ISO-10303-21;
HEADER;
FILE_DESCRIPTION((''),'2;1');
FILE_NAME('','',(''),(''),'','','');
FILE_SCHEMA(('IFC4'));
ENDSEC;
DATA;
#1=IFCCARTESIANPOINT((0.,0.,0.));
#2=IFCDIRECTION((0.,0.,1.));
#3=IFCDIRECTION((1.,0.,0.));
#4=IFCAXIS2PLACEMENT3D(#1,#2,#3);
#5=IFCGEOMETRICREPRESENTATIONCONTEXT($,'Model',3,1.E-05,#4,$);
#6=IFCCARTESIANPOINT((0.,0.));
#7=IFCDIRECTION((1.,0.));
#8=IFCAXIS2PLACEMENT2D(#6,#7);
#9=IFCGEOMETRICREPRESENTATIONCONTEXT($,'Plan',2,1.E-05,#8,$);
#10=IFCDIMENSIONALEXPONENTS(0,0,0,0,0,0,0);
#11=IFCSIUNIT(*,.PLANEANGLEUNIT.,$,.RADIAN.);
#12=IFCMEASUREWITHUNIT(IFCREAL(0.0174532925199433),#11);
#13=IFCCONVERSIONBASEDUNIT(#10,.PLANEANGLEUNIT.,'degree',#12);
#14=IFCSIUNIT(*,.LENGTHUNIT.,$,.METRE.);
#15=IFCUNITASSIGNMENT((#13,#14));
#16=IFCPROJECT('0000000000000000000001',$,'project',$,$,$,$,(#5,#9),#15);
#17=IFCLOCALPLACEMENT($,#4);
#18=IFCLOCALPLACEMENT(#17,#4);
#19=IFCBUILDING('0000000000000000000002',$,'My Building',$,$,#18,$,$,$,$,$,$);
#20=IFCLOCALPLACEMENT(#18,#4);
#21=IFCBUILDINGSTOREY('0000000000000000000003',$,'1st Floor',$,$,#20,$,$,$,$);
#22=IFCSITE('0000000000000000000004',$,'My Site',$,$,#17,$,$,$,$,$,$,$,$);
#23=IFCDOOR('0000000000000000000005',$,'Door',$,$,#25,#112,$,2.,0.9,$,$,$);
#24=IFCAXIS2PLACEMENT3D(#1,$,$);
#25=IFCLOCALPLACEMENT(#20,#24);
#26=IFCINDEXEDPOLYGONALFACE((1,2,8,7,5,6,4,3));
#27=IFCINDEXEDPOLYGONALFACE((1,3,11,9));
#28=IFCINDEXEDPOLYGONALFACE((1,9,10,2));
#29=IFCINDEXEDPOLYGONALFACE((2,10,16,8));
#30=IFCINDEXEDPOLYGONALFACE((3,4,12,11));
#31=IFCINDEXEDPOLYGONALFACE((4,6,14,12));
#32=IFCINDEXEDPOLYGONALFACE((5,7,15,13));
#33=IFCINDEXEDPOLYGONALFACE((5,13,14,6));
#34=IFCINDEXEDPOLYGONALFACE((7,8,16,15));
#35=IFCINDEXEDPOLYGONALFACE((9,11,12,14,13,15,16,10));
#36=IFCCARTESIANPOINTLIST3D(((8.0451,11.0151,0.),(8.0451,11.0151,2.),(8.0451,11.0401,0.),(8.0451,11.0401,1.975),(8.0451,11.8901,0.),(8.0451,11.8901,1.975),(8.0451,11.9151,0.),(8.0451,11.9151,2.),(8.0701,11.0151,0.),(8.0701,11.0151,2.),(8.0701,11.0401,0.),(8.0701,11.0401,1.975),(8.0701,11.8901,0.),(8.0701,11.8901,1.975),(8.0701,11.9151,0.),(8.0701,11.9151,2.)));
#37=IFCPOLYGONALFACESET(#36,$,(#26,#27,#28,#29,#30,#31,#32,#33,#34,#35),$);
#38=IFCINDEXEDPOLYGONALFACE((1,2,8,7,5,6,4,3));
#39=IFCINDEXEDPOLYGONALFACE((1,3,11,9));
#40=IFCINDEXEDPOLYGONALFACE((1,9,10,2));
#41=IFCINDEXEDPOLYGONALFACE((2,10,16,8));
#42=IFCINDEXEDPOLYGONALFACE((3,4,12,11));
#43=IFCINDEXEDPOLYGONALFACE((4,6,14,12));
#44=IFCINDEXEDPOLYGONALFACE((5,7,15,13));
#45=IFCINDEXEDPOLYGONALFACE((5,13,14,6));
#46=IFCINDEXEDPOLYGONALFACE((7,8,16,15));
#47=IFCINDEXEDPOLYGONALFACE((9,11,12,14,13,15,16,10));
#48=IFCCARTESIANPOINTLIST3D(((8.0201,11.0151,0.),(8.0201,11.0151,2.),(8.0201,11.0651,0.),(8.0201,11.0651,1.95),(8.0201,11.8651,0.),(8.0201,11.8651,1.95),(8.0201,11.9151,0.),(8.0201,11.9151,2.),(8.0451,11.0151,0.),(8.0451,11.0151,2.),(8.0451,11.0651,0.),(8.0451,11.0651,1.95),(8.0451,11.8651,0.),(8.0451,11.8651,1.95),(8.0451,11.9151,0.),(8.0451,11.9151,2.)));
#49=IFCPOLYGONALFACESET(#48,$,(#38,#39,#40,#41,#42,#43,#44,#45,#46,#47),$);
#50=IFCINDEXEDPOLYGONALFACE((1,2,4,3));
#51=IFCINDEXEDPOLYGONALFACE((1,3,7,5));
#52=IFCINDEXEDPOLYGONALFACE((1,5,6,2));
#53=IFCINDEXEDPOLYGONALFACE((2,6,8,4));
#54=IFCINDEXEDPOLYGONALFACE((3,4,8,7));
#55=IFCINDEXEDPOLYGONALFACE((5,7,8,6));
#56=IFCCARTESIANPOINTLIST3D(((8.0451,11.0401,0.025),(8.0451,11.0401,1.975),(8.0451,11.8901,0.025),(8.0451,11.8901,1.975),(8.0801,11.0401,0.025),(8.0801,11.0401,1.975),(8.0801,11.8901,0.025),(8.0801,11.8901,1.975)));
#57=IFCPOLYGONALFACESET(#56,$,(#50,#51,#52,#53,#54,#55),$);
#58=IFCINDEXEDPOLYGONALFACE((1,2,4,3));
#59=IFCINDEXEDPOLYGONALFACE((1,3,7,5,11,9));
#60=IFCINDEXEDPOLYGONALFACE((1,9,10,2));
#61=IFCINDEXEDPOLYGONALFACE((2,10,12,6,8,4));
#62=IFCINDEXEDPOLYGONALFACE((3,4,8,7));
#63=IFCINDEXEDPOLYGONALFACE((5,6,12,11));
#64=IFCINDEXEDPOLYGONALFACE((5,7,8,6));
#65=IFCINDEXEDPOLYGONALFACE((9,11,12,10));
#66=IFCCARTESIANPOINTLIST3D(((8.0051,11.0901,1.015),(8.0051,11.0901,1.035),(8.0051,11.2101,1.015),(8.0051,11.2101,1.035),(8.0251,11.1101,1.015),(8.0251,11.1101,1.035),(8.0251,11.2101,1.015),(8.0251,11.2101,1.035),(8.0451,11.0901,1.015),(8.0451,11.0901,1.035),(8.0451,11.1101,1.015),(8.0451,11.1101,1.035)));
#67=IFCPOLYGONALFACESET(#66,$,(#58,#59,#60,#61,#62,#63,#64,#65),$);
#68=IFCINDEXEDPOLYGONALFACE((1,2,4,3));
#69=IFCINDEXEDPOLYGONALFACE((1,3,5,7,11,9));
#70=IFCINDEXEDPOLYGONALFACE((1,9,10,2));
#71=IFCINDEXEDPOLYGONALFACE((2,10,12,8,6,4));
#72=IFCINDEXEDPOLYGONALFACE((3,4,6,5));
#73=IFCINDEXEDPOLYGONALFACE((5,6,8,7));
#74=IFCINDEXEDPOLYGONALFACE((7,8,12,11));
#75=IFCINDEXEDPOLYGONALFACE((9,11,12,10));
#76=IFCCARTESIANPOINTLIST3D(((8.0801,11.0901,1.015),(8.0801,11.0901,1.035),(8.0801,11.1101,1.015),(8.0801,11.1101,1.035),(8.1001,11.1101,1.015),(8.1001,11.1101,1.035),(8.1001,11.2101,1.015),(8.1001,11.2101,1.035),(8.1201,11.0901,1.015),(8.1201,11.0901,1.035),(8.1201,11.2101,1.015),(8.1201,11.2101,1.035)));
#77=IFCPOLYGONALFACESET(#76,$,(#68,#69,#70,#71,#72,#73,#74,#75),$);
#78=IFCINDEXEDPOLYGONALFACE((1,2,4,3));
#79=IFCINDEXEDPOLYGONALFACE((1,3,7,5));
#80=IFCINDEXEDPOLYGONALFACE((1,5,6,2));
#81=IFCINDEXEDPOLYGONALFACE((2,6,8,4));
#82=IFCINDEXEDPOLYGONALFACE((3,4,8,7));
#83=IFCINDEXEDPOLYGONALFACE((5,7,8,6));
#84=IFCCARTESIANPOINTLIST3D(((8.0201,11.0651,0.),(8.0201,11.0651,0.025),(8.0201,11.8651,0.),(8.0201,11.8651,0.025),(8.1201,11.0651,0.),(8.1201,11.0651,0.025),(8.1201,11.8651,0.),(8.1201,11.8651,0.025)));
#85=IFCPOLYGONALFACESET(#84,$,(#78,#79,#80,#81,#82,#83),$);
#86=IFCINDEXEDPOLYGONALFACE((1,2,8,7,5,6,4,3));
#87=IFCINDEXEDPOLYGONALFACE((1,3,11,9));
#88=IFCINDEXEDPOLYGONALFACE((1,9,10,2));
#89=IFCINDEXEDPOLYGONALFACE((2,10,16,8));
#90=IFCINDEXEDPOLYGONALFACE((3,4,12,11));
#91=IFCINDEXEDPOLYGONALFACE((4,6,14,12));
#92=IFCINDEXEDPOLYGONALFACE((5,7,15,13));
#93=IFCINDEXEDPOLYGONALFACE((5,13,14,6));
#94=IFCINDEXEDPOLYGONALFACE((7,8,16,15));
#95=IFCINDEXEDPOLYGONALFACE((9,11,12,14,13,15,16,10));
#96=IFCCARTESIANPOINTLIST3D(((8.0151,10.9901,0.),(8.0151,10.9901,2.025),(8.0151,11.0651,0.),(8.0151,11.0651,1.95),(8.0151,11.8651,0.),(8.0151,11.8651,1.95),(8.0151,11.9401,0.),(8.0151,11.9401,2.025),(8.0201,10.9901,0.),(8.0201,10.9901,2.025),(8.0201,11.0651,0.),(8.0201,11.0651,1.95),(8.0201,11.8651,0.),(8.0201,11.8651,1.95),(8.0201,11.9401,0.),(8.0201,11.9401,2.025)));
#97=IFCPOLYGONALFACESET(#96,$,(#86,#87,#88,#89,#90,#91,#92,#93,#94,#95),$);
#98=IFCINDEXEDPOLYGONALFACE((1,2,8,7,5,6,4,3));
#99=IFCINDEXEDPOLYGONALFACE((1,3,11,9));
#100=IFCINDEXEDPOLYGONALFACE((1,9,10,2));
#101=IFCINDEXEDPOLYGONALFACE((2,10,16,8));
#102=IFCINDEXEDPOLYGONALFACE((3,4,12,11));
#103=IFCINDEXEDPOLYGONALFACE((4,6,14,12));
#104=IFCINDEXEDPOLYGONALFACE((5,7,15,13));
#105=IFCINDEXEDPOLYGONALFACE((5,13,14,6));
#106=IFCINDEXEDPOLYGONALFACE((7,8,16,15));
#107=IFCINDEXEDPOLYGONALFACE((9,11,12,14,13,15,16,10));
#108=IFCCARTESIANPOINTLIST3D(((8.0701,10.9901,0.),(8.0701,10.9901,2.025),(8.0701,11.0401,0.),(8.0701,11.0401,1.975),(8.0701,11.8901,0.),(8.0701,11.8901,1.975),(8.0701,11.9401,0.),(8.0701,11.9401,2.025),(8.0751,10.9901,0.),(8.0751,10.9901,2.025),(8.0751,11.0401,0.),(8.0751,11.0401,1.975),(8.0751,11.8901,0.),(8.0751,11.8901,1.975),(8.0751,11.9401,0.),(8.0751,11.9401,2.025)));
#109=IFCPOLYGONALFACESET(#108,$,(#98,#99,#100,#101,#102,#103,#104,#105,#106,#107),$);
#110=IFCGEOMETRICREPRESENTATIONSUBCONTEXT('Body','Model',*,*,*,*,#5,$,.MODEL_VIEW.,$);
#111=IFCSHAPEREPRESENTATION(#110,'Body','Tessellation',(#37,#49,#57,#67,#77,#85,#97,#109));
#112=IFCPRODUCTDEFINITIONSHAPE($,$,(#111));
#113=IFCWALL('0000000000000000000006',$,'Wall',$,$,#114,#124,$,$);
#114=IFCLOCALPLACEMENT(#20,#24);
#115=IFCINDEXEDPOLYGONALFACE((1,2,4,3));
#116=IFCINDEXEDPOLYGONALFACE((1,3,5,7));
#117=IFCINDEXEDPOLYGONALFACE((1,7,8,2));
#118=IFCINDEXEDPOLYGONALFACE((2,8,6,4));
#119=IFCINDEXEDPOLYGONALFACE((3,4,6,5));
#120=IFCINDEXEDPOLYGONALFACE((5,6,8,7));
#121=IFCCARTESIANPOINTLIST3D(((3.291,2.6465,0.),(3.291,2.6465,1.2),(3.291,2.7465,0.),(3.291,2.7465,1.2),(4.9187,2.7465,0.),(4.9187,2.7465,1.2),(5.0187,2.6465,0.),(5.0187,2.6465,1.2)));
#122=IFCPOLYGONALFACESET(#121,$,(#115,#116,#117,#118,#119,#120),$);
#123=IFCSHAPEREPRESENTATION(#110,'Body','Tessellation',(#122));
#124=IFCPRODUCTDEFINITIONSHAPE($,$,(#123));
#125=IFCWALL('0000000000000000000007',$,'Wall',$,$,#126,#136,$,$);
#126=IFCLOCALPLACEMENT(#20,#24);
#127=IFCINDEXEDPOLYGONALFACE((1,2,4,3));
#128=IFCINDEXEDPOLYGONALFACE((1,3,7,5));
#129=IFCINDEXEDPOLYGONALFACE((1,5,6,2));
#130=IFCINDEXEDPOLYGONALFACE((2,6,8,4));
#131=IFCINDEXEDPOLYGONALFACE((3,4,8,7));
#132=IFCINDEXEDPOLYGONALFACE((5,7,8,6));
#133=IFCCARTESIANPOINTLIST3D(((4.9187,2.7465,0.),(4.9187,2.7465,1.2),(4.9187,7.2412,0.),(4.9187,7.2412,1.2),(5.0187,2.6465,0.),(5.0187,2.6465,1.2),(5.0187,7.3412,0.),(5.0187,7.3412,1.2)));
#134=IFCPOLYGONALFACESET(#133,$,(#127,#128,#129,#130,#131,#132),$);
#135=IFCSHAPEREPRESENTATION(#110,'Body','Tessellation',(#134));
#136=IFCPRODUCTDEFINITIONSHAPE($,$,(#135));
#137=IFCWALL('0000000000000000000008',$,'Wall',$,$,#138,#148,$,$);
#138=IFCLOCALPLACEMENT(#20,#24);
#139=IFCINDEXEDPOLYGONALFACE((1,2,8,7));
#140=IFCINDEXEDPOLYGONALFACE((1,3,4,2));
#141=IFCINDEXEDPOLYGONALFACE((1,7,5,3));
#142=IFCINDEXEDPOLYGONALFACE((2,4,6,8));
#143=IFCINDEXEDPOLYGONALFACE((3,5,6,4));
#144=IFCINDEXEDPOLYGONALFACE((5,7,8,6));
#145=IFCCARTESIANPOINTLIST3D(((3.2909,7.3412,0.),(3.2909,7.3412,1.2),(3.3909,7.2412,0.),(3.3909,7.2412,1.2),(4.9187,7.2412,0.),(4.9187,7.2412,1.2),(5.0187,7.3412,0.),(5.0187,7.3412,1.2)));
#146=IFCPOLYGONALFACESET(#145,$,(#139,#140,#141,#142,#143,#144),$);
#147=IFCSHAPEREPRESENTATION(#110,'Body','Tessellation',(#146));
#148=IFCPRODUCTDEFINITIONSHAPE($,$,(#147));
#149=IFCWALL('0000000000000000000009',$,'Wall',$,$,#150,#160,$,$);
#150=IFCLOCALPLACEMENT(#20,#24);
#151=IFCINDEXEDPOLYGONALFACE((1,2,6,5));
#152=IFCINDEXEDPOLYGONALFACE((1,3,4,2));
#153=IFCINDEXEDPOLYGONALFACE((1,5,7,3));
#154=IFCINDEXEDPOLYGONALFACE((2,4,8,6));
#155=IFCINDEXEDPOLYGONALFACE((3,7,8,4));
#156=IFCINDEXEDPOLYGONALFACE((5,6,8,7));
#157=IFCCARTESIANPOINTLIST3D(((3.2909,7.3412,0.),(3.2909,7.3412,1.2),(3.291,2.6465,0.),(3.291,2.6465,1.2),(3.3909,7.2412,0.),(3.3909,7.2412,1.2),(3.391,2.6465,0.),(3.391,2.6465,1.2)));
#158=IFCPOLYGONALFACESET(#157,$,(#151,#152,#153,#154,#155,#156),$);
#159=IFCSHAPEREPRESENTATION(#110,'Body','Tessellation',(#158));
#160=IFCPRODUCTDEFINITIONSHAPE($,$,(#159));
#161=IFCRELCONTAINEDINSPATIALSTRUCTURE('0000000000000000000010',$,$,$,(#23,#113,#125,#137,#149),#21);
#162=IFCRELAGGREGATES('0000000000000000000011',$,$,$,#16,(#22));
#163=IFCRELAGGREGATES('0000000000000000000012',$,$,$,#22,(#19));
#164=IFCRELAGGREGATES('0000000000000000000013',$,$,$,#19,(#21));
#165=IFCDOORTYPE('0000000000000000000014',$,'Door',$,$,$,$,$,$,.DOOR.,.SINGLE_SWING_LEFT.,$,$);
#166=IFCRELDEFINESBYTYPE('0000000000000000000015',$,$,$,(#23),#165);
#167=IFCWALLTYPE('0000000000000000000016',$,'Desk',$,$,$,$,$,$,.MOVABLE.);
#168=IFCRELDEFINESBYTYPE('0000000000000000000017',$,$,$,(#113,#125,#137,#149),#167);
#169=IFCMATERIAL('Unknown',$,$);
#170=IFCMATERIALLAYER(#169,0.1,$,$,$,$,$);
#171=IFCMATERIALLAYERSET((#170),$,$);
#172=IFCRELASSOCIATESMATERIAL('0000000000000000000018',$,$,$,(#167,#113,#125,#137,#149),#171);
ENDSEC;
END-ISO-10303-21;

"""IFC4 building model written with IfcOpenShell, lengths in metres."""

from ifc_helpers import new_model, entity, si_unit, converted_unit, frame, origin_with_axes, origin_2d_with_axis, place, context, subcontext, project, spatial, line, indexed_curve, outline, extrude, shape, source, transform, mapped, material, layer, layer_set, layer_usage, type_object, type_shapes, element, save


model = new_model("IFC4")

# Units and contexts
model_context = context("Model", 3, precision=1e-05, world=origin_with_axes())
plan_context = context("Plan", 2, precision=1e-05, world=origin_2d_with_axis())
body_context_1 = subcontext(model_context, "Body", "Model", "MODEL_VIEW")
body_context_2 = subcontext(plan_context, "Body", "Plan", "PLAN_VIEW")
ifc_project = project(units=[converted_unit("PLANEANGLEUNIT", "degree", entity("IfcReal", 0.0174532925199433), si_unit("PLANEANGLEUNIT", "RADIAN"), dimensions=[0, 0, 0, 0, 0, 0, 0]), si_unit("LENGTHUNIT", "METRE")], contexts=[model_context, plan_context])

# Site, building, storey
site_placement = place(None, origin_with_axes())
site = spatial("IfcSite", under=ifc_project, at=site_placement, Name="My Site")
building_placement = place(site_placement, origin_with_axes())
building = spatial("IfcBuilding", under=site, at=building_placement, Name="My Building")
storey_placement = place(building_placement, origin_with_axes())
storey = spatial("IfcBuildingStorey", under=building, at=storey_placement, Name="1st Floor")

# Shared definitions
ifc_material = material(Name="Unknown")

# Shared definitions
door_type = type_object("IfcDoorType", Name="Door", OperationType="SINGLE_SWING_LEFT", PredefinedType="DOOR")
shared_shape_1 = source(origin_with_axes(), body_context_1, "Body", "SweptSolid", [
    extrude(outline(indexed_curve([(0.0, 0.0), (0.0, 2.0), (0.9, 2.0), (0.9, 0.0), (0.875, 0.0), (0.875, 1.975), (0.025, 1.975), (0.025, 0.0)], segments=[line(1, 2, 3, 4, 5, 6, 7, 8, 1)])), frame((0.0, 0.025, 0.0), z_axis=(0.0, -1.0, 0.0), x_axis=(1.0, 0.0, 0.0)), (0.0, 0.0, -1.0), 0.025),
    extrude(outline(indexed_curve([(0.0, 0.0), (0.0, 2.0), (0.9, 2.0), (0.9, 0.0), (0.85, 0.0), (0.85, 1.95), (0.05, 1.95), (0.05, 0.0)], segments=[line(1, 2, 3, 4, 5, 6, 7, 8, 1)])), frame((0.0, 0.0, 0.0), z_axis=(0.0, -1.0, 0.0), x_axis=(1.0, 0.0, 0.0)), (0.0, 0.0, -1.0), 0.025),
    extrude(outline(indexed_curve([(0.0, 0.0), (0.85, 0.0), (0.85, 0.035), (0.0, 0.035)], segments=[line(1, 2, 3, 4, 1)])), frame((0.025, 0.025, 0.025), z_axis=(0.0, 0.0, 1.0), x_axis=(1.0, 0.0, 0.0)), (0.0, 0.0, 1.0), 1.95),
    extrude(outline(indexed_curve([(0.0, 0.0), (0.0, -0.04), (-0.12, -0.04), (-0.12, -0.02), (-0.02, -0.02), (-0.02, 0.0)], segments=[line(1, 2, 3, 4, 5, 6, 1)])), frame((0.825, 0.025, 1.015), z_axis=(0.0, 0.0, 1.0), x_axis=(1.0, 0.0, 0.0)), (0.0, 0.0, 1.0), 0.02),
    extrude(outline(indexed_curve([(0.0, 0.0), (0.0, 0.04), (-0.12, 0.04), (-0.12, 0.02), (-0.02, 0.02), (-0.02, 0.0)], segments=[line(1, 2, 3, 4, 5, 6, 1)])), frame((0.825, 0.06, 1.015), z_axis=(0.0, 0.0, 1.0), x_axis=(1.0, 0.0, 0.0)), (0.0, 0.0, 1.0), 0.02),
    extrude(outline(indexed_curve([(0.0, 0.0), (0.8, 0.0), (0.8, 0.1), (0.0, 0.1)], segments=[line(1, 2, 3, 4, 1)])), frame((0.05, 0.0, 0.0), z_axis=(0.0, 0.0, 1.0), x_axis=(1.0, 0.0, 0.0)), (0.0, 0.0, 1.0), 0.025),
    extrude(outline(indexed_curve([(0.0, 0.0), (0.0, 2.025), (0.95, 2.025), (0.95, 0.0), (0.875, 0.0), (0.875, 1.95), (0.075, 1.95), (0.075, 0.0)], segments=[line(1, 2, 3, 4, 5, 6, 7, 8, 1)])), frame((-0.025, -0.005, 0.0), z_axis=(0.0, -1.0, 0.0), x_axis=(1.0, 0.0, 0.0)), (0.0, 0.0, -1.0), 0.005),
    extrude(outline(indexed_curve([(0.0, 0.0), (0.0, 2.025), (0.95, 2.025), (0.95, 0.0), (0.9, 0.0), (0.9, 1.975), (0.05, 1.975), (0.05, 0.0)], segments=[line(1, 2, 3, 4, 5, 6, 7, 8, 1)])), frame((-0.025, 0.05, 0.0), z_axis=(0.0, -1.0, 0.0), x_axis=(1.0, 0.0, 0.0)), (0.0, 0.0, -1.0), 0.005),
])
shared_shape_2 = source(origin_with_axes(), body_context_2, "Body", "Curve2D", [
    entity("IfcIndexedPolyCurve", entity("IfcCartesianPointList2D", [[0.0, 0.0], [0.0, 0.05], [0.025, 0.05], [0.025, 0.025], [0.05, 0.025], [0.05, 0.0]]), [entity("IfcLineIndex", [1, 2, 3, 4, 5, 6, 1])]),
    entity("IfcIndexedPolyCurve", entity("IfcCartesianPointList2D", [[0.9, 0.0], [0.9, 0.05], [0.875, 0.05], [0.875, 0.025], [0.85, 0.025], [0.85, 0.0]]), [entity("IfcLineIndex", [1, 2, 3, 4, 5, 6, 1])]),
    entity("IfcTrimmedCurve", entity("IfcEllipse", entity("IfcAxis2Placement2D", entity("IfcCartesianPoint", [0.06, 0.05]), entity("IfcDirection", [1.0, 0.0])), 0.815, 0.85), [entity("IfcCartesianPoint", [0.875, 0.05])], [entity("IfcCartesianPoint", [0.06, 0.9])], True, "CARTESIAN"),
    entity("IfcIndexedPolyCurve", entity("IfcCartesianPointList2D", [[0.025, 0.05], [0.06, 0.05], [0.06, 0.9], [0.025, 0.9]]), [entity("IfcLineIndex", [1, 2, 3, 4, 1])]),
])
type_shapes(door_type, [shared_shape_1, shared_shape_2])

# Door
placement_1 = place(storey_placement, frame((8.0201, 20.0, 0.0), z_axis=(0.0, 0.0, 1.0), x_axis=(0.0, -1.0, 0.0)))
placement_2 = place(placement_1, frame((8.0849, 0.0, 0.0), z_axis=(0.0, 0.0, 1.0), x_axis=(1.0, 0.0, 0.0)))
door_1_placement = place(placement_2, frame((0.0, 0.0, 0.0), z_axis=(0.0, 0.0, 1.0), x_axis=(1.0, 0.0, 0.0)))
element("IfcDoor", 1, at=door_1_placement, inside=storey, type_object=door_type, Name="Door", OverallHeight=2.0, OverallWidth=0.9, shapes=[
    shape(body_context_1, "Body", "MappedRepresentation", [mapped(shared_shape_1, transform((0.0, 0.0, 0.0), x_axis=(1.0, 0.0, 0.0), y_axis=(0.0, 1.0, 0.0), z_axis=(0.0, 0.0, 1.0), scale=1.0))]),
    shape(body_context_2, "Body", "MappedRepresentation", [mapped(shared_shape_2, transform((0.0, 0.0, 0.0), x_axis=(1.0, 0.0, 0.0), y_axis=(0.0, 1.0, 0.0), z_axis=(0.0, 0.0, 1.0), scale=1.0))]),
])

# Walls
ifc_layer_1 = layer(ifc_material, 0.1)
ifc_layer_set_1 = layer_set([ifc_layer_1])
ifc_layer_usage_1 = layer_usage(ifc_layer_set_1, "AXIS2", "POSITIVE", 0.0)
wall_type_1 = type_object("IfcWallType", Name="Desk", PredefinedType="MOVABLE", material=ifc_layer_set_1)
wall_1_placement = place(storey_placement, frame((3.291, 2.6465, 0.0), z_axis=(0.0, 0.0, 1.0), x_axis=(1.0, 0.0, 0.0)))
element("IfcWall", 2, at=wall_1_placement, inside=storey, type_object=wall_type_1, material=ifc_layer_usage_1, Name="Wall", context=body_context_1, shape_type="SweptSolid", body=[
    extrude(outline(indexed_curve([(0.0, 0.0), (0.0, 0.1), (1.6277, 0.1), (1.7277, 0.0)], segments=[line(1, 2, 3, 4, 1)])), origin_with_axes(), (0.0, 0.0, 1.0), 1.2),
])
ifc_layer_usage_2 = layer_usage(ifc_layer_set_1, "AXIS2", "POSITIVE", 0.0)
wall_2_placement = place(storey_placement, frame((5.0187, 2.6465, 0.0), z_axis=(0.0, 0.0, 1.0), x_axis=(0.0, 1.0, 0.0)))
element("IfcWall", 3, at=wall_2_placement, inside=storey, type_object=wall_type_1, material=ifc_layer_usage_2, Name="Wall", context=body_context_1, shape_type="SweptSolid", body=[
    extrude(outline(indexed_curve([(0.0, 0.0), (0.1, 0.1), (4.5947, 0.1), (4.6947, 0.0)], segments=[line(1, 2, 3, 4, 1)])), origin_with_axes(), (0.0, 0.0, 1.0), 1.2),
])
ifc_layer_usage_3 = layer_usage(ifc_layer_set_1, "AXIS2", "POSITIVE", 0.0)
wall_3_placement = place(storey_placement, frame((5.0187, 7.3412, 0.0), z_axis=(0.0, 0.0, 1.0), x_axis=(-1.0, 0.0, 0.0)))
element("IfcWall", 4, at=wall_3_placement, inside=storey, type_object=wall_type_1, material=ifc_layer_usage_3, Name="Wall", context=body_context_1, shape_type="SweptSolid", body=[
    extrude(outline(indexed_curve([(0.0, 0.0), (0.1, 0.1), (1.6277, 0.1), (1.7277, 0.0)], segments=[line(1, 2, 3, 4, 1)])), origin_with_axes(), (0.0, 0.0, 1.0), 1.2),
])
ifc_layer_usage_4 = layer_usage(ifc_layer_set_1, "AXIS2", "POSITIVE", 0.0)
wall_4_placement = place(storey_placement, frame((3.2909, 7.3412, 0.0), z_axis=(0.0, 0.0, 1.0), x_axis=(0.0, -1.0, 0.0)))
element("IfcWall", 5, at=wall_4_placement, inside=storey, type_object=wall_type_1, material=ifc_layer_usage_4, Name="Wall", context=body_context_1, shape_type="SweptSolid", body=[
    extrude(outline(indexed_curve([(0.0, 0.0), (0.1, 0.1), (4.6947, 0.1), (4.6947, 0.0)], segments=[line(1, 2, 3, 4, 1)])), origin_with_axes(), (0.0, 0.0, 1.0), 1.2),
])

save(model, "model.ifc")
